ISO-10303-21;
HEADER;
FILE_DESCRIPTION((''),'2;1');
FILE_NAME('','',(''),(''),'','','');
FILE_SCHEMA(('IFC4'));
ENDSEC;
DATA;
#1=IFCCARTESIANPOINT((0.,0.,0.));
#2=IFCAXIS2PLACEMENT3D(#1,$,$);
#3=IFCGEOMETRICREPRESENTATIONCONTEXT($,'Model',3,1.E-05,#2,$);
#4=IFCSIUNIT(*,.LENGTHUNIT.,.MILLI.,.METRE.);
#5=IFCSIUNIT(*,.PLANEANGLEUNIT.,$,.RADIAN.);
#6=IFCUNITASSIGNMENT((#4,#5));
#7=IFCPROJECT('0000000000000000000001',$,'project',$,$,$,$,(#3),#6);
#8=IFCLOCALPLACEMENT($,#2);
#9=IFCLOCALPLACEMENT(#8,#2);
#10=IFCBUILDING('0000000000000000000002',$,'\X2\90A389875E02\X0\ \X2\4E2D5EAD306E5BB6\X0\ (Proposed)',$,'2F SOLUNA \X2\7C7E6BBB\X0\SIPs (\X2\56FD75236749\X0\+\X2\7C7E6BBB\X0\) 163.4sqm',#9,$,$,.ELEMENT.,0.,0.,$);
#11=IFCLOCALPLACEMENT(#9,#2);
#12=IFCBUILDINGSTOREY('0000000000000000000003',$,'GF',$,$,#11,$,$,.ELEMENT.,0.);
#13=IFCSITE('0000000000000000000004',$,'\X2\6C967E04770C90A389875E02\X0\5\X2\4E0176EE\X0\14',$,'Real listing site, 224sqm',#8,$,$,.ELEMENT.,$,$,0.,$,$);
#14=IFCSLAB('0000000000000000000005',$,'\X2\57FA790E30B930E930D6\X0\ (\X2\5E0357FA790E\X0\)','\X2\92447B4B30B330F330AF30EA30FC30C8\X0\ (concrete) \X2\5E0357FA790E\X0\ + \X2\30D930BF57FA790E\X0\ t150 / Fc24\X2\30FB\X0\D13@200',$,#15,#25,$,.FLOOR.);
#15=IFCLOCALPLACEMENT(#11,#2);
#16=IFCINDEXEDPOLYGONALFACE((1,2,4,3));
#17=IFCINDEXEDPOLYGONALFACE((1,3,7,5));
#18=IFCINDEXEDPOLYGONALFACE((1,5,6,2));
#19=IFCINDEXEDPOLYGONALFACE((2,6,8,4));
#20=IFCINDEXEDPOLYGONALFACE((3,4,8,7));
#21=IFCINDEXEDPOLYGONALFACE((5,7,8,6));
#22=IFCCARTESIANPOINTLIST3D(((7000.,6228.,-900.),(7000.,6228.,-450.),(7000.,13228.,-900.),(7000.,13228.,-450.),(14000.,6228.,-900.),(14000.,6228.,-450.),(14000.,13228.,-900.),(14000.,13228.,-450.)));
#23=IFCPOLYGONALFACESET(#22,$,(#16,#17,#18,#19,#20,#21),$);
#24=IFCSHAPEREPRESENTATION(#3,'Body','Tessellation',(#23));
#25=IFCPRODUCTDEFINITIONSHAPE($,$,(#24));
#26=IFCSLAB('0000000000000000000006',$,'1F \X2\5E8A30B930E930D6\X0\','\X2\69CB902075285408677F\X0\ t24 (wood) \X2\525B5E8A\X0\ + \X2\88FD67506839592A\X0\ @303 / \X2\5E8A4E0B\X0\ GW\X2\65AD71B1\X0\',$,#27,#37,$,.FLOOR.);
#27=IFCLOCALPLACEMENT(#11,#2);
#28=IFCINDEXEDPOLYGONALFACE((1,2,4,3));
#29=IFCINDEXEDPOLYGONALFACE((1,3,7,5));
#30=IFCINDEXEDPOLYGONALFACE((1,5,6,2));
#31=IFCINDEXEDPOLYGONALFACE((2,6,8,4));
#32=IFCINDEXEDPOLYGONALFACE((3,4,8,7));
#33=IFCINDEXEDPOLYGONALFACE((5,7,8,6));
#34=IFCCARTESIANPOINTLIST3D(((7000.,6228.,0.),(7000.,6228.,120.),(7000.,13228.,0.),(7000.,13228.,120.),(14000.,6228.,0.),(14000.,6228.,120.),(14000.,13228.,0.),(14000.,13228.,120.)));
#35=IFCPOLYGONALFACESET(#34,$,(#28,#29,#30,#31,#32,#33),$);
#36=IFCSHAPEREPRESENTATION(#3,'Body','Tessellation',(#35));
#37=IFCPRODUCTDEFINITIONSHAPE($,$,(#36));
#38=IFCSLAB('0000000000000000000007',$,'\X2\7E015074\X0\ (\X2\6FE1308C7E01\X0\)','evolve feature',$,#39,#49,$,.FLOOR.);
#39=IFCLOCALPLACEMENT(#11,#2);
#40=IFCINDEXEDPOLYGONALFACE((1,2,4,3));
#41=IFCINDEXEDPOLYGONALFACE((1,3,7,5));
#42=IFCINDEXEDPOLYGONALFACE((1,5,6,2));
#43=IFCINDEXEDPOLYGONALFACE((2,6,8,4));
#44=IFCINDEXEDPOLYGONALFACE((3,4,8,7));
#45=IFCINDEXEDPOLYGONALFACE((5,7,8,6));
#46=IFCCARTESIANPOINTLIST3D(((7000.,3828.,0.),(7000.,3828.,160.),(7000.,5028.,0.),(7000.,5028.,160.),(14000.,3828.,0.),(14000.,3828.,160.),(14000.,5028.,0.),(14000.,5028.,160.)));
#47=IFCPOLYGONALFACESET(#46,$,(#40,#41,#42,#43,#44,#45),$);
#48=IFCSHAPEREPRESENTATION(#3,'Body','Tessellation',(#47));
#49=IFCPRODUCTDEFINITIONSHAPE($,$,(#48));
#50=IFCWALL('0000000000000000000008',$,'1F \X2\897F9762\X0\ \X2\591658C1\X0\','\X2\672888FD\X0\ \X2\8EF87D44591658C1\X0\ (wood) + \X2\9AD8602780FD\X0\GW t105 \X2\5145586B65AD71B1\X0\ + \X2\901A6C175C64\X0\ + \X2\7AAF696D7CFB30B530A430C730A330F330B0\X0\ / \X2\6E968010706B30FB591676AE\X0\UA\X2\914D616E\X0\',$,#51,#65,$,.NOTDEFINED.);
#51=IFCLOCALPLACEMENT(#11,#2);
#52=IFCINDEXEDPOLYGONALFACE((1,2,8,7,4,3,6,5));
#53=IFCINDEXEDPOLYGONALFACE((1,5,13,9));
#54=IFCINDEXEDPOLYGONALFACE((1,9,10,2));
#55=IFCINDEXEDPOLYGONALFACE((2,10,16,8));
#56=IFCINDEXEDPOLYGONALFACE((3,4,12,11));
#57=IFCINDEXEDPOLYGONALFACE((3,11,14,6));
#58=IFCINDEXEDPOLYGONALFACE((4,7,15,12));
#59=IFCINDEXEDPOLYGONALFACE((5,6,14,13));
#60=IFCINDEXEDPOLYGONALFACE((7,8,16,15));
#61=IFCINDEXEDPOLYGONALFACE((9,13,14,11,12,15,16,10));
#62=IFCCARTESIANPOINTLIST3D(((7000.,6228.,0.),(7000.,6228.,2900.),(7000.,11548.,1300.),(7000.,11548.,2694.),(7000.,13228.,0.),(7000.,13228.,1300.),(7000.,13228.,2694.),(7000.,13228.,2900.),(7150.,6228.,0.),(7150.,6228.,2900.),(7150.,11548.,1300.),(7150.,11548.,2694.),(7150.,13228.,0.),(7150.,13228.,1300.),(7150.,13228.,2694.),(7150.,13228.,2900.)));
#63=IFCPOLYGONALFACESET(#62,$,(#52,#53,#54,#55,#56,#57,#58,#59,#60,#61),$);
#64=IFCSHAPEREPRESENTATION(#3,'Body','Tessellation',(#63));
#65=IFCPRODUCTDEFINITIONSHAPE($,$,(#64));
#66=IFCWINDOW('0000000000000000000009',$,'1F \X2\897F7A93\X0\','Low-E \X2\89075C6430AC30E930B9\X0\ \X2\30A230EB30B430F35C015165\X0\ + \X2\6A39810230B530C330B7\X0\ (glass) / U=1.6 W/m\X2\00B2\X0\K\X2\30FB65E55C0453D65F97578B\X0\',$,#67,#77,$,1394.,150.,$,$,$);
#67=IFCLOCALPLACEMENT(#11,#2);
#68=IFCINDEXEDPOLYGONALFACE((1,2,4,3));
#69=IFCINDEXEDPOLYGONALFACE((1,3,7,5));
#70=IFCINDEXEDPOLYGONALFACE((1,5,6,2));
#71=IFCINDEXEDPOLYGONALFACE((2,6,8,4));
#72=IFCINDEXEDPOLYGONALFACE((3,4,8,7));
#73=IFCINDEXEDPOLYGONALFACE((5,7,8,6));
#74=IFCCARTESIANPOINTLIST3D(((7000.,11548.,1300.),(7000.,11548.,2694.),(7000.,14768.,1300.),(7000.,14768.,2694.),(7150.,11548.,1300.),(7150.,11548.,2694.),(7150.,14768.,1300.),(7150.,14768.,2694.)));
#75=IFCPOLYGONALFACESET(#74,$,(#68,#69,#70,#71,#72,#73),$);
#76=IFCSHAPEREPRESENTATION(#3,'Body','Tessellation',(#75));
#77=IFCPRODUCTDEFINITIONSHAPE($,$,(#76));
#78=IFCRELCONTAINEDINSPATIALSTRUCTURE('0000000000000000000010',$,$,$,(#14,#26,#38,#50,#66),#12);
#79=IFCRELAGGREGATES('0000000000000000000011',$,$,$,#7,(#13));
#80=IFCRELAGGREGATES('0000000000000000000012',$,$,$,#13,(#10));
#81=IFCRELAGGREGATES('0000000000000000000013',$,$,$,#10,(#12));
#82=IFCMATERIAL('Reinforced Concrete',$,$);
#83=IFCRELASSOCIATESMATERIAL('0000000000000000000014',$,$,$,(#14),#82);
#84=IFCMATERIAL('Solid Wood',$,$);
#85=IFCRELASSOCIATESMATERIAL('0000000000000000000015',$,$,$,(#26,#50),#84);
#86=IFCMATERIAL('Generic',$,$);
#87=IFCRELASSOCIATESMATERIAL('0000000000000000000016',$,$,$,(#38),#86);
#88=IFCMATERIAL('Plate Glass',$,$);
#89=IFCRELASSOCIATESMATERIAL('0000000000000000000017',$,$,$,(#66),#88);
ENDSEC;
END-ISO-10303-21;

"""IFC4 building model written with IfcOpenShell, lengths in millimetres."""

from ifc_helpers import new_model, si_unit, frame, frame_2d, origin, place, context, project, spatial, rectangle, extrude, material, element, fill, save


model = new_model("IFC4")

# Units and contexts
model_context = context("Model", 3, precision=1e-05, world=origin())
ifc_project = project(units=[si_unit("LENGTHUNIT", "METRE", prefix="MILLI"), si_unit("PLANEANGLEUNIT", "RADIAN")], contexts=[model_context])

# Site, building, storey
site_placement = place(None, origin())
site = spatial("IfcSite", under=ifc_project, at=site_placement, Name="沖縄県那覇市5丁目14", ObjectType="Real listing site, 224sqm", CompositionType="ELEMENT", RefElevation=0.0)
building_placement = place(site_placement, origin())
building = spatial("IfcBuilding", under=site, at=building_placement, Name="那覇市 中庭の家 (Proposed)", ObjectType="2F SOLUNA 籾殻SIPs (国産杉+籾殻) 163.4sqm", CompositionType="ELEMENT", ElevationOfRefHeight=0.0, ElevationOfTerrain=0.0)
storey_placement = place(building_placement, origin())
storey = spatial("IfcBuildingStorey", under=building, at=storey_placement, Name="GF", CompositionType="ELEMENT", Elevation=0.0)

# Slabs
ifc_material_1 = material(Name="Reinforced Concrete")
slab_1_placement = place(storey_placement, frame((3500.0, 3114.0, -450.0)))
element("IfcSlab", 1, at=slab_1_placement, inside=storey, material=ifc_material_1, Name="基礎スラブ (布基礎)", Description="鉄筋コンクリート (concrete) 布基礎 + ベタ基礎 t150 / Fc24・D13@200", PredefinedType="FLOOR", context=model_context, shape_type="SweptSolid", body=[
    extrude(rectangle(XDim=7000.0, YDim=7000.0, at=frame_2d((3500.0, 3500.0))), frame((3500.0, 3114.0, -450.0)), (0.0, 0.0, 1.0), 450.0),
])
ifc_material_2 = material(Name="Solid Wood")
slab_2_placement = place(storey_placement, frame((3500.0, 3114.0, 0.0)))
element("IfcSlab", 2, at=slab_2_placement, inside=storey, material=ifc_material_2, Name="1F 床スラブ", Description="構造用合板 t24 (wood) 剛床 + 製材根太 @303 / 床下 GW断熱", PredefinedType="FLOOR", context=model_context, shape_type="SweptSolid", body=[
    extrude(rectangle(XDim=7000.0, YDim=7000.0, at=frame_2d((3500.0, 3500.0))), frame((3500.0, 3114.0, 0.0)), (0.0, 0.0, 1.0), 120.0),
])
ifc_material_3 = material(Name="Generic")
slab_3_placement = place(storey_placement, frame((3500.0, 1914.0, 0.0)))
element("IfcSlab", 3, at=slab_3_placement, inside=storey, material=ifc_material_3, Name="縁側 (濡れ縁)", Description="evolve feature", PredefinedType="FLOOR", context=model_context, shape_type="SweptSolid", body=[
    extrude(rectangle(XDim=7000.0, YDim=1200.0, at=frame_2d((3500.0, 600.0))), frame((3500.0, 1914.0, 0.0)), (0.0, 0.0, 1.0), 160.0),
])

# Shared definitions
ifc_material_4 = material(Name="Plate Glass")

# Wall, opening, window
wall_1_placement = place(storey_placement, frame((3500.0, 3114.0, 0.0)))
wall_1 = element("IfcWall", 4, at=wall_1_placement, inside=storey, material=ifc_material_2, Name="1F 西面 外壁", Description="木製 軸組外壁 (wood) + 高性能GW t105 充填断熱 + 通気層 + 窯業系サイディング / 準耐火・外皮UA配慮", PredefinedType="NOTDEFINED", context=model_context, shape_type="SweptSolid", body=[
    extrude(rectangle(XDim=150.0, YDim=7000.0, at=frame_2d((75.0, 3500.0))), frame((3500.0, 3114.0, 0.0)), (0.0, 0.0, 1.0), 2900.0),
])
opening_1_placement = place(storey_placement, frame((3500.0, 5774.0, 650.0)))
opening_1 = element("IfcOpeningElement", 5, at=opening_1_placement, cuts=wall_1, PredefinedType="NOTDEFINED", context=model_context, shape_type="SweptSolid", body=[
    extrude(rectangle(XDim=150.0, YDim=3220.0, at=frame_2d((75.0, 1610.0))), frame((3500.0, 5774.0, 650.0)), (0.0, 0.0, 1.0), 1394.0),
])
window_1_placement = place(storey_placement, frame((3500.0, 5774.0, 650.0)))
window_1 = element("IfcWindow", 6, at=window_1_placement, inside=storey, material=ifc_material_4, Name="1F 西窓", Description="Low-E 複層ガラス アルゴン封入 + 樹脂サッシ (glass) / U=1.6 W/m²K・日射取得型", OverallHeight=1394.0, OverallWidth=150.0, context=model_context, shape_type="SweptSolid", body=[
    extrude(rectangle(XDim=150.0, YDim=3220.0, at=frame_2d((75.0, 1610.0))), frame((3500.0, 5774.0, 650.0)), (0.0, 0.0, 1.0), 1394.0),
])
fill(opening_1, window_1)

save(model, "model.ifc")
